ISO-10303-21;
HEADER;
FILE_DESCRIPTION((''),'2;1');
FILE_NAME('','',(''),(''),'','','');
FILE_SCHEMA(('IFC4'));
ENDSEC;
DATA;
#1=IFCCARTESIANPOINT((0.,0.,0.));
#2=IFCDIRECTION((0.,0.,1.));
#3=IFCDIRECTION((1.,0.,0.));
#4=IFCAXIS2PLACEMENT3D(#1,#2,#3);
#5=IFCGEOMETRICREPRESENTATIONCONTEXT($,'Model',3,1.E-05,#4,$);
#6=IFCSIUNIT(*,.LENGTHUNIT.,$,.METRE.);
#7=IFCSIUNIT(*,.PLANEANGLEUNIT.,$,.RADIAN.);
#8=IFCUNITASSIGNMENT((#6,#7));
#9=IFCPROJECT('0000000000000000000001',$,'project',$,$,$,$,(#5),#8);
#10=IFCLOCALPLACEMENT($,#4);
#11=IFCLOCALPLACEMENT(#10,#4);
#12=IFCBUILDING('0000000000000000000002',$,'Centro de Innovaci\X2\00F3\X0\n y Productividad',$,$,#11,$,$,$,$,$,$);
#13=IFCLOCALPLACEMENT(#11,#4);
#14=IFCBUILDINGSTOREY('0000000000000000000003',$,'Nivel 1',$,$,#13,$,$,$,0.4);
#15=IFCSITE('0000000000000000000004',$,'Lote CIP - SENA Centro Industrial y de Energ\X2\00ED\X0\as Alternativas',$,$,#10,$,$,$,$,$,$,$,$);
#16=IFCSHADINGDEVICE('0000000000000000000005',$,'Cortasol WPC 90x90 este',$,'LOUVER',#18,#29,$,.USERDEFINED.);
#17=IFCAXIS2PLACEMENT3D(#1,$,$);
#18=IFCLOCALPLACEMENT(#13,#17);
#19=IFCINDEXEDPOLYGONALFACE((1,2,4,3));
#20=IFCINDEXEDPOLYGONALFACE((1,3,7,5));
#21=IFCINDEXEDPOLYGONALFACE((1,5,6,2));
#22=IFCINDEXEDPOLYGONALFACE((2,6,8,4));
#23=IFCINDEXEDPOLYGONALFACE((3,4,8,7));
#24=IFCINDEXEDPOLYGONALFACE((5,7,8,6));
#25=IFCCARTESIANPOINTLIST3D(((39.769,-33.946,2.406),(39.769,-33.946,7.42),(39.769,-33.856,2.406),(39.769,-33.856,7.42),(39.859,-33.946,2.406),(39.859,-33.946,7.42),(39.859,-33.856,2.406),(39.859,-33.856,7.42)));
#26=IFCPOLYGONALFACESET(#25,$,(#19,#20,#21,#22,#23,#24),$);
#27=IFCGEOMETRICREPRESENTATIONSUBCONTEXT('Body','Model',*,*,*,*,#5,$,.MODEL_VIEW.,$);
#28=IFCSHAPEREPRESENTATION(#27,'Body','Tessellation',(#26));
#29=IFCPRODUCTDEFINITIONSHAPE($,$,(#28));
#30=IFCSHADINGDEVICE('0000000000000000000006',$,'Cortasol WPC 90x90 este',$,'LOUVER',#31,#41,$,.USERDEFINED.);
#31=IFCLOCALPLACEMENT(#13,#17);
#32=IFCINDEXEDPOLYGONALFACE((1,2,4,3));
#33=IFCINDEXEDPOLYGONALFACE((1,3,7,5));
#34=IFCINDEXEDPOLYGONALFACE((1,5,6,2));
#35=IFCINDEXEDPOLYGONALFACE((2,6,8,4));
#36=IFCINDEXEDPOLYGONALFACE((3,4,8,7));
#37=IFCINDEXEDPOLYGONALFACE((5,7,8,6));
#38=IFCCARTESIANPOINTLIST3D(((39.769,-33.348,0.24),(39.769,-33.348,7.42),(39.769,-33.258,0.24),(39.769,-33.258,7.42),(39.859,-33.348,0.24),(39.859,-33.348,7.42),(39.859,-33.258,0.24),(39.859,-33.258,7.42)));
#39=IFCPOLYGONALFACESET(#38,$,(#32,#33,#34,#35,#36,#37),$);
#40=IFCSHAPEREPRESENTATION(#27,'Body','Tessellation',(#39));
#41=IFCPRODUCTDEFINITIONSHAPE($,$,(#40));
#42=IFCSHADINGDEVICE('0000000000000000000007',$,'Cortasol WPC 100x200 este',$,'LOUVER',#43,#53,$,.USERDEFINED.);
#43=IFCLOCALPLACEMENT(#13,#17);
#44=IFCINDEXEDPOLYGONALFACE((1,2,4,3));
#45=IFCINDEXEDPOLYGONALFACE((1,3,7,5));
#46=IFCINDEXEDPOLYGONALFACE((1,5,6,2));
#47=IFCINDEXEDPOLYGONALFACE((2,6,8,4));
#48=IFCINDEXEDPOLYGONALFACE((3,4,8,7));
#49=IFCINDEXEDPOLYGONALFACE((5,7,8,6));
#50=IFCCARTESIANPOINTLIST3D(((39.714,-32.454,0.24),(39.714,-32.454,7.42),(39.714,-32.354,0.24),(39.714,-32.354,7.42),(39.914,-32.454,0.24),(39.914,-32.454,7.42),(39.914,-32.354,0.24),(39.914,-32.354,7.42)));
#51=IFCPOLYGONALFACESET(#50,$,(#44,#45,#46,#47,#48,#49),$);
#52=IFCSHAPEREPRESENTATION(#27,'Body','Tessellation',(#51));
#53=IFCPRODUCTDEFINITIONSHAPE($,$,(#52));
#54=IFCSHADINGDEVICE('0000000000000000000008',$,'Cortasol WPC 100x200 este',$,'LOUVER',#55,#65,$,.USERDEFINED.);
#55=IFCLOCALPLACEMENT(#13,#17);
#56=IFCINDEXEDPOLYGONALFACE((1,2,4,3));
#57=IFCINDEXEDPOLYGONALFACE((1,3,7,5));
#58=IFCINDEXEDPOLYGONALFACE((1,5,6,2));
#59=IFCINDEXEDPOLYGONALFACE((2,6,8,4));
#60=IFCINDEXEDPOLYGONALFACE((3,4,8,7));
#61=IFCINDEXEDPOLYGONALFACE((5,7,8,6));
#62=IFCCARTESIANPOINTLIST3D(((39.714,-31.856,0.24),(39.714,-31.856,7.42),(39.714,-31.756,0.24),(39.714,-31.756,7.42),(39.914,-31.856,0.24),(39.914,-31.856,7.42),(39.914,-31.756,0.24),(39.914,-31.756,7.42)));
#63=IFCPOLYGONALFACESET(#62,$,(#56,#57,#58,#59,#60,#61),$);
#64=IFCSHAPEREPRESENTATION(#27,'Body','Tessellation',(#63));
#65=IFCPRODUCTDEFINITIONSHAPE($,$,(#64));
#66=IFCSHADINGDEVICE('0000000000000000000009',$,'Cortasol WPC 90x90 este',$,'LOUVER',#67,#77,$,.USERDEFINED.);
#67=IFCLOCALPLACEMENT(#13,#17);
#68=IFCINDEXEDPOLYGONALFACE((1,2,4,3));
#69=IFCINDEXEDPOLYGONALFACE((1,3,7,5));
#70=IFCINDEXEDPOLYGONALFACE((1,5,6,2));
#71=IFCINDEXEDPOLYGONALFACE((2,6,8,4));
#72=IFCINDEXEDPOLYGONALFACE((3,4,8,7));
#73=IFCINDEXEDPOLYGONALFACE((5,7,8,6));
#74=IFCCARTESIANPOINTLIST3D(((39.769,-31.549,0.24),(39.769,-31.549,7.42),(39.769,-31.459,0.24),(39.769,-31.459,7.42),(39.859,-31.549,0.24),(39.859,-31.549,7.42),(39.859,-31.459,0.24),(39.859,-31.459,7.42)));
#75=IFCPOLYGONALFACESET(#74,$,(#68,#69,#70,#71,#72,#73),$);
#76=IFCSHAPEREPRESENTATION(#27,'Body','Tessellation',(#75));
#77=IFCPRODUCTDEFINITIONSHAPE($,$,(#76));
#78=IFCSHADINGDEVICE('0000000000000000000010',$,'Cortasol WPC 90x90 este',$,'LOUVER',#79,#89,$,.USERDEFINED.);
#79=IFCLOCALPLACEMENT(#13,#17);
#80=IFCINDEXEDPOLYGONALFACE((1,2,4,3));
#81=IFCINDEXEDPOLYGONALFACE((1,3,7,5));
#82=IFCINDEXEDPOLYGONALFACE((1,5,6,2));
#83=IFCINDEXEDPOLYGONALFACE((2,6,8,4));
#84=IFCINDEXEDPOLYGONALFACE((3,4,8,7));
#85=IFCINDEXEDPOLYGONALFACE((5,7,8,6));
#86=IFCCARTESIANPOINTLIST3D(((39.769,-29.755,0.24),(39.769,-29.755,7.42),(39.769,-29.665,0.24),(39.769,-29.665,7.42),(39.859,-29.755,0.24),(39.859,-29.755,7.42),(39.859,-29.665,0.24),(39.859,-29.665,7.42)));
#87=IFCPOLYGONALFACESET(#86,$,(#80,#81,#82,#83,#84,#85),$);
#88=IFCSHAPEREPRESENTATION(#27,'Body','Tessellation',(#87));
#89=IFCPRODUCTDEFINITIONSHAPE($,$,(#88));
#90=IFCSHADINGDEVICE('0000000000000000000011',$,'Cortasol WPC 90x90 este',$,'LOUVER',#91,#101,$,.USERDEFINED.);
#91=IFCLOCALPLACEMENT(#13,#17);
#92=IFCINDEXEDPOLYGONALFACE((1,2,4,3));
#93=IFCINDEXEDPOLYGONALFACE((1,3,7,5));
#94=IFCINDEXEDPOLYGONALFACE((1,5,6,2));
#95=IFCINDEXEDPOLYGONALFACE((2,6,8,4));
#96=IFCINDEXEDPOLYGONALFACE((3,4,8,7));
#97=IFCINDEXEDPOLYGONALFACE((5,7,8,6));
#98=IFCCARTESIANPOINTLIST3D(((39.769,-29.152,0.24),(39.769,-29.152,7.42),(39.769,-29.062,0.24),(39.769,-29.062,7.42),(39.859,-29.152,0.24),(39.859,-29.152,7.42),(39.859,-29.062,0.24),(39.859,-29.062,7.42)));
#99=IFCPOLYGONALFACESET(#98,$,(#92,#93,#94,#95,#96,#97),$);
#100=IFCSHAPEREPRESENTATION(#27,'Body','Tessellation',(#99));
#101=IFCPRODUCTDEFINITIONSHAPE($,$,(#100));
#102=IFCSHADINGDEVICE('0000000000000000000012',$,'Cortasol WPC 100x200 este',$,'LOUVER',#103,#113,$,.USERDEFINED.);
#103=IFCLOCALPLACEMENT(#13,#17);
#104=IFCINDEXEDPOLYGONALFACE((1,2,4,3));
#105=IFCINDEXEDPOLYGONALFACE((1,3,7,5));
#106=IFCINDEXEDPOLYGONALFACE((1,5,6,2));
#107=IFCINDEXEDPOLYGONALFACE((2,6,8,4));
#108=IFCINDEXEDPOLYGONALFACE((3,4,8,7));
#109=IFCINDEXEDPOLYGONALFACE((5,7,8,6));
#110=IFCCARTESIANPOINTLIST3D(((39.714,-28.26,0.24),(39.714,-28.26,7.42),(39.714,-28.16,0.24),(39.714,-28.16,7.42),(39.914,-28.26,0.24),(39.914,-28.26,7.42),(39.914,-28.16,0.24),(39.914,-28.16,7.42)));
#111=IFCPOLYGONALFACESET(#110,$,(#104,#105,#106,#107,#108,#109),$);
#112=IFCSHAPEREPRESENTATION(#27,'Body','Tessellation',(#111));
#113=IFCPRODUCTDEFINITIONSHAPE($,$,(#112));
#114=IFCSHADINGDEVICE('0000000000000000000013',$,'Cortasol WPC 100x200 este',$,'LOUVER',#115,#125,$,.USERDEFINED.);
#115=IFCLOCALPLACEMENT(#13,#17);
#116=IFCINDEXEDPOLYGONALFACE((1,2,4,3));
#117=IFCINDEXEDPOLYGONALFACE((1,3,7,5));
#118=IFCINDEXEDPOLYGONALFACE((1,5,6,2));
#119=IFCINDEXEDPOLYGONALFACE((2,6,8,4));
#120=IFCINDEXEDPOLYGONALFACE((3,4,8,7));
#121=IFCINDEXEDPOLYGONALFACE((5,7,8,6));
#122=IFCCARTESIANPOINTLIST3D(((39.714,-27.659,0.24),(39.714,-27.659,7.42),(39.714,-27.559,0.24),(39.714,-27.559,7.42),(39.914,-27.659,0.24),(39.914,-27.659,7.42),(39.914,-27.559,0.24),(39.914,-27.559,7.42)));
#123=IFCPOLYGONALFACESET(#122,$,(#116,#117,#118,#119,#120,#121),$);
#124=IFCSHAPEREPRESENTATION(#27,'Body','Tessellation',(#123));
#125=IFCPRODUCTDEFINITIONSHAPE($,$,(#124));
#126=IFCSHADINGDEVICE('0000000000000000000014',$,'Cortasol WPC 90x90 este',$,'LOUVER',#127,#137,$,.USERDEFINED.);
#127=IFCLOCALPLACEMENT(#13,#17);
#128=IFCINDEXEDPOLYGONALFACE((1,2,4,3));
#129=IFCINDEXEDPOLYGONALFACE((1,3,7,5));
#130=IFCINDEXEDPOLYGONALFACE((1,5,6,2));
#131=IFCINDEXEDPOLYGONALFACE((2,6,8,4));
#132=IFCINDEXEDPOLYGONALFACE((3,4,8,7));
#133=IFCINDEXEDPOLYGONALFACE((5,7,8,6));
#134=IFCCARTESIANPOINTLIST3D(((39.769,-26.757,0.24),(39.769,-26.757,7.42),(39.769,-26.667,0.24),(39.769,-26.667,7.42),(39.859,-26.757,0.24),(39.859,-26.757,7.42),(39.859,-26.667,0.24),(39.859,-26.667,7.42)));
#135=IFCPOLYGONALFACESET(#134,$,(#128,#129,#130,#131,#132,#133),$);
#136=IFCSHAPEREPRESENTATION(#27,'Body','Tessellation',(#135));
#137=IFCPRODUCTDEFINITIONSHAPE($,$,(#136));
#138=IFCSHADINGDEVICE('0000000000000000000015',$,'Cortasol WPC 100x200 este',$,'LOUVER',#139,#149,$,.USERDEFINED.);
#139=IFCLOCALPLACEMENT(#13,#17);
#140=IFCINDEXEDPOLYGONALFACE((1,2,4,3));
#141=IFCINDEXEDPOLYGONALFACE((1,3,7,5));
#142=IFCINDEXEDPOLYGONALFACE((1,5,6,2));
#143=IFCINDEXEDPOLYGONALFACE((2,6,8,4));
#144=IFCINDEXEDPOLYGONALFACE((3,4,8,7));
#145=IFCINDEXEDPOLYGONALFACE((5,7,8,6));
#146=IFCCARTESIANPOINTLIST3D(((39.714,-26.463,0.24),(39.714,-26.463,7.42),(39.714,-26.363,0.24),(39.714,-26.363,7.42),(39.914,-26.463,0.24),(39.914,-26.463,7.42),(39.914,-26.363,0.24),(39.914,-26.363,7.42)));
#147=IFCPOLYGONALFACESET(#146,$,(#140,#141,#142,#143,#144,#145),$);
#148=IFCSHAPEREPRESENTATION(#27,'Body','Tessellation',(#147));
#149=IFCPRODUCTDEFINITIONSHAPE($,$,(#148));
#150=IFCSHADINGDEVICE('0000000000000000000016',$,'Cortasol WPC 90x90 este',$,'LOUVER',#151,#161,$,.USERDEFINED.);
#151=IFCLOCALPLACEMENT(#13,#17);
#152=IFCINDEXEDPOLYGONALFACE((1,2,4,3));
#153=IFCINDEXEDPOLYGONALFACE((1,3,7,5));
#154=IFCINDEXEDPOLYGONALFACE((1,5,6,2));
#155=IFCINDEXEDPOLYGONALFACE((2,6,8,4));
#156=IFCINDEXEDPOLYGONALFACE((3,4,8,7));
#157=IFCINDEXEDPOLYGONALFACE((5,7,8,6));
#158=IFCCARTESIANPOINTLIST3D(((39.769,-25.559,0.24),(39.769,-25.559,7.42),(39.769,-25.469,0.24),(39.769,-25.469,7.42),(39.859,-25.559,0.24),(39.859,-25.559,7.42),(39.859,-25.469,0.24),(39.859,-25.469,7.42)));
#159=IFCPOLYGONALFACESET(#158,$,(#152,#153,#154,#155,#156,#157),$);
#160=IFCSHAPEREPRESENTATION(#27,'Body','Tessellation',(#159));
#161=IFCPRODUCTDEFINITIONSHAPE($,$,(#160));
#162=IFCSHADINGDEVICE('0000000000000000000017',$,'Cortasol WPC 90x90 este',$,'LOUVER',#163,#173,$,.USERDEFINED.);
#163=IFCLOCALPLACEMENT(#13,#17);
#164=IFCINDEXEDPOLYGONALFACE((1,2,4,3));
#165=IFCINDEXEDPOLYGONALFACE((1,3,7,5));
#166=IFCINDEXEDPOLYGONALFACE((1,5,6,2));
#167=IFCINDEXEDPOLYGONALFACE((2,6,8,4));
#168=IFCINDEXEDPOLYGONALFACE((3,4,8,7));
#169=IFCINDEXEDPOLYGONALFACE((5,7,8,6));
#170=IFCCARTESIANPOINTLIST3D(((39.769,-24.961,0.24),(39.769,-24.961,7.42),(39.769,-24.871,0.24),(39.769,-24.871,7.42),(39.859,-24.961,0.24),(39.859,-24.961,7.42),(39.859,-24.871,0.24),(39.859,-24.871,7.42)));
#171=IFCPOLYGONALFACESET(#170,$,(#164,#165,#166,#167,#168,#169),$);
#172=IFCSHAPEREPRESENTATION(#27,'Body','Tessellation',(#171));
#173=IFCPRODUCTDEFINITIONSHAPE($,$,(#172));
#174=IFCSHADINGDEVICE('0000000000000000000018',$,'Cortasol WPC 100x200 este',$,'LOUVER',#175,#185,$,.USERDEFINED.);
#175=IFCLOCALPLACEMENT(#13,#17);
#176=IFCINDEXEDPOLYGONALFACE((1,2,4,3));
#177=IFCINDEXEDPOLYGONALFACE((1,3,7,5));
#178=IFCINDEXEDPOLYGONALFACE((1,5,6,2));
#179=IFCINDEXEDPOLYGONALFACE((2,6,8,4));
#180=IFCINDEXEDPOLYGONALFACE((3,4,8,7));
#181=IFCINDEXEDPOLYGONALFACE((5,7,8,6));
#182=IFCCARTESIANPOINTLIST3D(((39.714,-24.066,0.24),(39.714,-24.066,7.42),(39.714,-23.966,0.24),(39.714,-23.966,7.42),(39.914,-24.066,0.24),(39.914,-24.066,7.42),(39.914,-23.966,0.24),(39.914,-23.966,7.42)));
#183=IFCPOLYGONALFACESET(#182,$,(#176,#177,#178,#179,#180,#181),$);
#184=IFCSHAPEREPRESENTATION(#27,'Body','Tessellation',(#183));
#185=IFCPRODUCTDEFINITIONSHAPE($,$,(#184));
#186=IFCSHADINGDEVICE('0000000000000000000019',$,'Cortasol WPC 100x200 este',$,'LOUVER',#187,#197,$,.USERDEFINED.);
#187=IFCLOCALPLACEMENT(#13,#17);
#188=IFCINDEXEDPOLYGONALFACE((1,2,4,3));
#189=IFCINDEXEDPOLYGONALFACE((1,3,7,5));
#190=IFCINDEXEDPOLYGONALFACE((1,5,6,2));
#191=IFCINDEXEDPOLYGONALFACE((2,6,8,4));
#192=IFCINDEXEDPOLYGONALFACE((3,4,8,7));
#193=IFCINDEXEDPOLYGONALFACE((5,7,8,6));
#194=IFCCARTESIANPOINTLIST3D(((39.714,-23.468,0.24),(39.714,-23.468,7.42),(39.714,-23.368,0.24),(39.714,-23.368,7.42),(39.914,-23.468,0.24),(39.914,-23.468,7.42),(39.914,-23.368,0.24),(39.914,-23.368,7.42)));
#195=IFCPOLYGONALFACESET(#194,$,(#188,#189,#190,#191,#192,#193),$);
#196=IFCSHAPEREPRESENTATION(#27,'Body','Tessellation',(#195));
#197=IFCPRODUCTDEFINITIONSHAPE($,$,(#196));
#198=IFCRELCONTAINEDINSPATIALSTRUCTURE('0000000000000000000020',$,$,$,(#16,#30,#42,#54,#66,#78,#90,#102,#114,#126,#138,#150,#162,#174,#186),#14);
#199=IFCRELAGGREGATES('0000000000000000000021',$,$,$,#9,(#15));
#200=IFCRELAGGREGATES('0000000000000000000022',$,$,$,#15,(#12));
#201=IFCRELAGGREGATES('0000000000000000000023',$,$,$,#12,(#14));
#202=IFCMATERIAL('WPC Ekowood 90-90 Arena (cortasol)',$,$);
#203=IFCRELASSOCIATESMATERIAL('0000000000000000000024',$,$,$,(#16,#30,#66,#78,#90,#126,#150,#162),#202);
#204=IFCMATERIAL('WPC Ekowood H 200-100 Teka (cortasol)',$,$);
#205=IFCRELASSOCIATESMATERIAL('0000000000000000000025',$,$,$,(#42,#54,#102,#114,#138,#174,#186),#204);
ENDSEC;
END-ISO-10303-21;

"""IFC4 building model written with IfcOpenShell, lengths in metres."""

from ifc_helpers import new_model, si_unit, frame, origin_with_axes, place, context, subcontext, project, spatial, polyline, outline, extrude, material, element, save


model = new_model("IFC4")

# Units and contexts
model_context = context("Model", 3, precision=1e-05, world=origin_with_axes())
body_context = subcontext(model_context, "Body", "Model", "MODEL_VIEW")
ifc_project = project(units=[si_unit("LENGTHUNIT", "METRE"), si_unit("PLANEANGLEUNIT", "RADIAN")], contexts=[model_context])

# Site, building, storey
site_placement = place(None, origin_with_axes())
site = spatial("IfcSite", under=ifc_project, at=site_placement, Name="Lote CIP - SENA Centro Industrial y de Energías Alternativas")
building_placement = place(site_placement, origin_with_axes())
building = spatial("IfcBuilding", under=site, at=building_placement, Name="Centro de Innovación y Productividad")
storey_placement = place(building_placement, origin_with_axes())
storey = spatial("IfcBuildingStorey", under=building, at=storey_placement, Name="Nivel 1", Elevation=0.4)

# Shading devices
ifc_material_1 = material(Name="WPC Ekowood 90-90 Arena (cortasol)")
shading_device_1_placement = place(storey_placement, origin_with_axes())
element("IfcShadingDevice", 1, at=shading_device_1_placement, inside=storey, material=ifc_material_1, Name="Cortasol WPC 90x90 este", ObjectType="LOUVER", PredefinedType="USERDEFINED", context=body_context, shape_type="SweptSolid", body=[
    extrude(outline(polyline([(39.859, -33.946), (39.769, -33.946), (39.769, -33.856), (39.859, -33.856), (39.859, -33.946)])), frame((0.0, 0.0, 2.406)), (0.0, 0.0, 1.0), 5.014),
])
shading_device_2_placement = place(storey_placement, origin_with_axes())
element("IfcShadingDevice", 2, at=shading_device_2_placement, inside=storey, material=ifc_material_1, Name="Cortasol WPC 90x90 este", ObjectType="LOUVER", PredefinedType="USERDEFINED", context=body_context, shape_type="SweptSolid", body=[
    extrude(outline(polyline([(39.859, -33.348), (39.769, -33.348), (39.769, -33.258), (39.859, -33.258), (39.859, -33.348)])), frame((0.0, 0.0, 0.24)), (0.0, 0.0, 1.0), 7.18),
])
ifc_material_2 = material(Name="WPC Ekowood H 200-100 Teka (cortasol)")
shading_device_3_placement = place(storey_placement, origin_with_axes())
element("IfcShadingDevice", 3, at=shading_device_3_placement, inside=storey, material=ifc_material_2, Name="Cortasol WPC 100x200 este", ObjectType="LOUVER", PredefinedType="USERDEFINED", context=body_context, shape_type="SweptSolid", body=[
    extrude(outline(polyline([(39.914, -32.454), (39.714, -32.454), (39.714, -32.354), (39.914, -32.354), (39.914, -32.454)])), frame((0.0, 0.0, 0.24)), (0.0, 0.0, 1.0), 7.18),
])
shading_device_4_placement = place(storey_placement, origin_with_axes())
element("IfcShadingDevice", 4, at=shading_device_4_placement, inside=storey, material=ifc_material_2, Name="Cortasol WPC 100x200 este", ObjectType="LOUVER", PredefinedType="USERDEFINED", context=body_context, shape_type="SweptSolid", body=[
    extrude(outline(polyline([(39.914, -31.856), (39.714, -31.856), (39.714, -31.756), (39.914, -31.756), (39.914, -31.856)])), frame((0.0, 0.0, 0.24)), (0.0, 0.0, 1.0), 7.18),
])
shading_device_5_placement = place(storey_placement, origin_with_axes())
element("IfcShadingDevice", 5, at=shading_device_5_placement, inside=storey, material=ifc_material_1, Name="Cortasol WPC 90x90 este", ObjectType="LOUVER", PredefinedType="USERDEFINED", context=body_context, shape_type="SweptSolid", body=[
    extrude(outline(polyline([(39.859, -31.549), (39.769, -31.549), (39.769, -31.459), (39.859, -31.459), (39.859, -31.549)])), frame((0.0, 0.0, 0.24)), (0.0, 0.0, 1.0), 7.18),
])
shading_device_6_placement = place(storey_placement, origin_with_axes())
element("IfcShadingDevice", 6, at=shading_device_6_placement, inside=storey, material=ifc_material_1, Name="Cortasol WPC 90x90 este", ObjectType="LOUVER", PredefinedType="USERDEFINED", context=body_context, shape_type="SweptSolid", body=[
    extrude(outline(polyline([(39.859, -29.755), (39.769, -29.755), (39.769, -29.665), (39.859, -29.665), (39.859, -29.755)])), frame((0.0, 0.0, 0.24)), (0.0, 0.0, 1.0), 7.18),
])
shading_device_7_placement = place(storey_placement, origin_with_axes())
element("IfcShadingDevice", 7, at=shading_device_7_placement, inside=storey, material=ifc_material_1, Name="Cortasol WPC 90x90 este", ObjectType="LOUVER", PredefinedType="USERDEFINED", context=body_context, shape_type="SweptSolid", body=[
    extrude(outline(polyline([(39.859, -29.152), (39.769, -29.152), (39.769, -29.062), (39.859, -29.062), (39.859, -29.152)])), frame((0.0, 0.0, 0.24)), (0.0, 0.0, 1.0), 7.18),
])
shading_device_8_placement = place(storey_placement, origin_with_axes())
element("IfcShadingDevice", 8, at=shading_device_8_placement, inside=storey, material=ifc_material_2, Name="Cortasol WPC 100x200 este", ObjectType="LOUVER", PredefinedType="USERDEFINED", context=body_context, shape_type="SweptSolid", body=[
    extrude(outline(polyline([(39.914, -28.26), (39.714, -28.26), (39.714, -28.16), (39.914, -28.16), (39.914, -28.26)])), frame((0.0, 0.0, 0.24)), (0.0, 0.0, 1.0), 7.18),
])
shading_device_9_placement = place(storey_placement, origin_with_axes())
element("IfcShadingDevice", 9, at=shading_device_9_placement, inside=storey, material=ifc_material_2, Name="Cortasol WPC 100x200 este", ObjectType="LOUVER", PredefinedType="USERDEFINED", context=body_context, shape_type="SweptSolid", body=[
    extrude(outline(polyline([(39.914, -27.659), (39.714, -27.659), (39.714, -27.559), (39.914, -27.559), (39.914, -27.659)])), frame((0.0, 0.0, 0.24)), (0.0, 0.0, 1.0), 7.18),
])
shading_device_10_placement = place(storey_placement, origin_with_axes())
element("IfcShadingDevice", 10, at=shading_device_10_placement, inside=storey, material=ifc_material_1, Name="Cortasol WPC 90x90 este", ObjectType="LOUVER", PredefinedType="USERDEFINED", context=body_context, shape_type="SweptSolid", body=[
    extrude(outline(polyline([(39.859, -26.757), (39.769, -26.757), (39.769, -26.667), (39.859, -26.667), (39.859, -26.757)])), frame((0.0, 0.0, 0.24)), (0.0, 0.0, 1.0), 7.18),
])
shading_device_11_placement = place(storey_placement, origin_with_axes())
element("IfcShadingDevice", 11, at=shading_device_11_placement, inside=storey, material=ifc_material_2, Name="Cortasol WPC 100x200 este", ObjectType="LOUVER", PredefinedType="USERDEFINED", context=body_context, shape_type="SweptSolid", body=[
    extrude(outline(polyline([(39.914, -26.463), (39.714, -26.463), (39.714, -26.363), (39.914, -26.363), (39.914, -26.463)])), frame((0.0, 0.0, 0.24)), (0.0, 0.0, 1.0), 7.18),
])
shading_device_12_placement = place(storey_placement, origin_with_axes())
element("IfcShadingDevice", 12, at=shading_device_12_placement, inside=storey, material=ifc_material_1, Name="Cortasol WPC 90x90 este", ObjectType="LOUVER", PredefinedType="USERDEFINED", context=body_context, shape_type="SweptSolid", body=[
    extrude(outline(polyline([(39.859, -25.559), (39.769, -25.559), (39.769, -25.469), (39.859, -25.469), (39.859, -25.559)])), frame((0.0, 0.0, 0.24)), (0.0, 0.0, 1.0), 7.18),
])
shading_device_13_placement = place(storey_placement, origin_with_axes())
element("IfcShadingDevice", 13, at=shading_device_13_placement, inside=storey, material=ifc_material_1, Name="Cortasol WPC 90x90 este", ObjectType="LOUVER", PredefinedType="USERDEFINED", context=body_context, shape_type="SweptSolid", body=[
    extrude(outline(polyline([(39.859, -24.961), (39.769, -24.961), (39.769, -24.871), (39.859, -24.871), (39.859, -24.961)])), frame((0.0, 0.0, 0.24)), (0.0, 0.0, 1.0), 7.18),
])
shading_device_14_placement = place(storey_placement, origin_with_axes())
element("IfcShadingDevice", 14, at=shading_device_14_placement, inside=storey, material=ifc_material_2, Name="Cortasol WPC 100x200 este", ObjectType="LOUVER", PredefinedType="USERDEFINED", context=body_context, shape_type="SweptSolid", body=[
    extrude(outline(polyline([(39.914, -24.066), (39.714, -24.066), (39.714, -23.966), (39.914, -23.966), (39.914, -24.066)])), frame((0.0, 0.0, 0.24)), (0.0, 0.0, 1.0), 7.18),
])
shading_device_15_placement = place(storey_placement, origin_with_axes())
element("IfcShadingDevice", 15, at=shading_device_15_placement, inside=storey, material=ifc_material_2, Name="Cortasol WPC 100x200 este", ObjectType="LOUVER", PredefinedType="USERDEFINED", context=body_context, shape_type="SweptSolid", body=[
    extrude(outline(polyline([(39.914, -23.468), (39.714, -23.468), (39.714, -23.368), (39.914, -23.368), (39.914, -23.468)])), frame((0.0, 0.0, 0.24)), (0.0, 0.0, 1.0), 7.18),
])

save(model, "model.ifc")
